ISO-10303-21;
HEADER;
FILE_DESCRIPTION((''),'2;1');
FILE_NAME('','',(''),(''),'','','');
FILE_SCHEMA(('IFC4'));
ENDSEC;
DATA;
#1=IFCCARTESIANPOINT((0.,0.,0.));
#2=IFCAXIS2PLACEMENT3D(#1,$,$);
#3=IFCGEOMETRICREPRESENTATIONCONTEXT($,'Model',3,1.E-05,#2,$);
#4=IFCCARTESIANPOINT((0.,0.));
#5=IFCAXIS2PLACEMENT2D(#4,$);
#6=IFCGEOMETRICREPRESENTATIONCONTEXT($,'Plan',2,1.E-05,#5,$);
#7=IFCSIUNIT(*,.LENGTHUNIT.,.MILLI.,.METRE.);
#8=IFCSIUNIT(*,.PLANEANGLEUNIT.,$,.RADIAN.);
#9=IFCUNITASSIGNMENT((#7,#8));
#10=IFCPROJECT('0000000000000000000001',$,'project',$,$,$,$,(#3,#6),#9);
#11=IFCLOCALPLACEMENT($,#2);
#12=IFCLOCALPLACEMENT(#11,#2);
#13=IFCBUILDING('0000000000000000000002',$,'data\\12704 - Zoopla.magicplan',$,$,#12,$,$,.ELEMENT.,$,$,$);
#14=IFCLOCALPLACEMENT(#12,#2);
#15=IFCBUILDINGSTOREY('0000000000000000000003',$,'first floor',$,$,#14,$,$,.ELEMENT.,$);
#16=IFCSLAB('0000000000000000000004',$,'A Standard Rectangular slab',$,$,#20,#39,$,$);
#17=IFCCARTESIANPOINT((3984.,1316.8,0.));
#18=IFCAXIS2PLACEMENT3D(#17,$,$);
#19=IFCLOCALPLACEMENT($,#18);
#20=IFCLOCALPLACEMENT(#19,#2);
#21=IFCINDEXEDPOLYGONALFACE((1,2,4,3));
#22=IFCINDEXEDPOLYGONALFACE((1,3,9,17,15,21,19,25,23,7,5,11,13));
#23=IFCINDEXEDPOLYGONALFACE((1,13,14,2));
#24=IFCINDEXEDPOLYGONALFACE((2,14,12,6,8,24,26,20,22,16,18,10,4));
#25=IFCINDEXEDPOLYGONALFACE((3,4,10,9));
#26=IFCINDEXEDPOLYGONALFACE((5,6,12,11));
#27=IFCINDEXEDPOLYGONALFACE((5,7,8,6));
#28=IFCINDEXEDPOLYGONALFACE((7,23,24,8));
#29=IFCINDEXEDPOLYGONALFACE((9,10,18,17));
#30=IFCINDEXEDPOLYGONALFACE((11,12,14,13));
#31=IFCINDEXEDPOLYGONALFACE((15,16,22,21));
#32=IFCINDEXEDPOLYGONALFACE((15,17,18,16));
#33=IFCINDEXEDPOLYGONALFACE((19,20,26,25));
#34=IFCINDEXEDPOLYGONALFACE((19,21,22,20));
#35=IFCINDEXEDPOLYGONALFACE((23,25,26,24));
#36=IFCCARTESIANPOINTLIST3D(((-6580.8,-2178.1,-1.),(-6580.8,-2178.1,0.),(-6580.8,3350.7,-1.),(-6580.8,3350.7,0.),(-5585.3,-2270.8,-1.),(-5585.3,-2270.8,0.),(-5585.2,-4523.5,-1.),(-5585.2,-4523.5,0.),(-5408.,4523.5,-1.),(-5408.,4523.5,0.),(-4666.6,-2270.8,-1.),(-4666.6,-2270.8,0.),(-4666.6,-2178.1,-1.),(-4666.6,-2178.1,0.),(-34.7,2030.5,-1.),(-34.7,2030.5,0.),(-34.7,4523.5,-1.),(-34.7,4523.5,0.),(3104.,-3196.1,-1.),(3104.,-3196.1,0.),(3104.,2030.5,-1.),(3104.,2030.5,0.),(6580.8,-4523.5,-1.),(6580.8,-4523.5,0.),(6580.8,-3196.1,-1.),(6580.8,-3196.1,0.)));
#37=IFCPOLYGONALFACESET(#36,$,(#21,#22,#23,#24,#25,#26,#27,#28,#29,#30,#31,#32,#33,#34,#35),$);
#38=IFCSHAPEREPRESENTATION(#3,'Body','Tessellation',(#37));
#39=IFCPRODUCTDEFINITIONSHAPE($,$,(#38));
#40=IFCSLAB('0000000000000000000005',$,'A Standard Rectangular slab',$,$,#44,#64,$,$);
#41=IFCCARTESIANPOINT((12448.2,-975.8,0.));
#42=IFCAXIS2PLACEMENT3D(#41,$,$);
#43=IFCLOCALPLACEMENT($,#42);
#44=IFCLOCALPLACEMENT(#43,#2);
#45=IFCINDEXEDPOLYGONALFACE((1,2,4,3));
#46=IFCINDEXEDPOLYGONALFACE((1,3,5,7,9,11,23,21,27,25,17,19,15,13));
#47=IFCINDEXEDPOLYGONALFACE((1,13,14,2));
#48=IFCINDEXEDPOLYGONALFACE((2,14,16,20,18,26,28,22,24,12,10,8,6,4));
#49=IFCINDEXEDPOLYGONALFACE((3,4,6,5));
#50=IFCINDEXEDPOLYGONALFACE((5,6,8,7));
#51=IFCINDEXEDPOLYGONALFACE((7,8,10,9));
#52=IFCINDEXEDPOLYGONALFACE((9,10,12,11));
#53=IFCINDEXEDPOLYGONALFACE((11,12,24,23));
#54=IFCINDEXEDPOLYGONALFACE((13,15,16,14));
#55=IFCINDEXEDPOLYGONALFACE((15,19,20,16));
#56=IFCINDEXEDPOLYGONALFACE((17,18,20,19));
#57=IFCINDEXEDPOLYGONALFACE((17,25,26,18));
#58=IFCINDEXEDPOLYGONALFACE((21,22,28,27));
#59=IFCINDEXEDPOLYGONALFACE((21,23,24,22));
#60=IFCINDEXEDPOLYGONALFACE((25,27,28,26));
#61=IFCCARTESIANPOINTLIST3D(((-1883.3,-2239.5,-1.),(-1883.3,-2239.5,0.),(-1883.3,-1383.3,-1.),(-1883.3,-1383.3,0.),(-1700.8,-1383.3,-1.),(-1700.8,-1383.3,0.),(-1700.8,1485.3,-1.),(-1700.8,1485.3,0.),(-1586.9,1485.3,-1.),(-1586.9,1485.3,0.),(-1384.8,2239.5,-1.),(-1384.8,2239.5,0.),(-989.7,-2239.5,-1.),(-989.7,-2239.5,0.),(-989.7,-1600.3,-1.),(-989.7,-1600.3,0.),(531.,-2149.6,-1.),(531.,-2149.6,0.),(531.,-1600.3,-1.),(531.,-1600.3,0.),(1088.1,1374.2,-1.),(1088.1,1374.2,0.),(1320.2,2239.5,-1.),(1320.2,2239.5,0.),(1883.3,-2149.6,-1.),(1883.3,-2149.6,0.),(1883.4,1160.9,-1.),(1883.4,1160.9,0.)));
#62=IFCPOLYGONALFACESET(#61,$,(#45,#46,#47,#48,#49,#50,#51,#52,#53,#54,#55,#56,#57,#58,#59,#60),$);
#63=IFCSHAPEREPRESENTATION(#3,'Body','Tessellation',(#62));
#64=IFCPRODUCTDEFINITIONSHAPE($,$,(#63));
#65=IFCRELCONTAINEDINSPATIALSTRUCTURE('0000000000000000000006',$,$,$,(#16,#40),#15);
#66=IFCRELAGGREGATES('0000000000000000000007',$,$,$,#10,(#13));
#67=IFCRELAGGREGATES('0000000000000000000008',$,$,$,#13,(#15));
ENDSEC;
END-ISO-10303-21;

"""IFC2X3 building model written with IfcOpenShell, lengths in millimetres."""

from ifc_helpers import new_model, si_unit, frame, origin, origin_2d, place, context, project, spatial, polyline, outline, extrude, element, save


model = new_model("IFC2X3")

# Units and contexts
model_context = context("Model", 3, precision=1e-05, world=origin())
plan_context = context("Plan", 2, precision=1e-05, world=origin_2d())
ifc_project = project(units=[si_unit("LENGTHUNIT", "METRE", prefix="MILLI"), si_unit("PLANEANGLEUNIT", "RADIAN")], contexts=[model_context, plan_context])

# Building, storey
placement_1 = place(None, origin())
building_placement = place(placement_1, origin())
building = spatial("IfcBuilding", under=ifc_project, at=building_placement, Name="data\\12704 - Zoopla.magicplan", CompositionType="ELEMENT")
storey_placement = place(building_placement, origin())
storey = spatial("IfcBuildingStorey", under=building, at=storey_placement, Name="first floor", CompositionType="ELEMENT")

# Slabs
placement_2 = place(None, frame((3984.0, 1316.8, 0.0)))
slab_1_placement = place(placement_2, origin())
element("IfcSlab", 1, at=slab_1_placement, inside=storey, Name="A Standard Rectangular slab", context=model_context, shape_type="SweptSolid", body=[
    extrude(outline(polyline([(-5585.2, -4523.5, 0.0), (-5585.3, -2270.8, 0.0), (-4666.6, -2270.8, 0.0), (-4666.6, -2178.1, 0.0), (-6580.8, -2178.1, 0.0), (-6580.8, 3350.7, 0.0), (-5408.0, 4523.5, 0.0), (-34.7, 4523.5, 0.0), (-34.7, 2030.5, 0.0), (3104.0, 2030.5, 0.0), (3104.0, -3196.1, 0.0), (6580.8, -3196.1, 0.0), (6580.8, -4523.5, 0.0), (-5585.2, -4523.5, 0.0)]), kind="CURVE"), origin(), (0.0, 0.0, -1.0), 1.0),
])
placement_3 = place(None, frame((12448.2, -975.8, 0.0)))
slab_2_placement = place(placement_3, origin())
element("IfcSlab", 2, at=slab_2_placement, inside=storey, Name="A Standard Rectangular slab", context=model_context, shape_type="SweptSolid", body=[
    extrude(outline(polyline([(1883.4, 1160.9, 0.0), (1883.3, -2149.6, 0.0), (531.0, -2149.6, 0.0), (531.0, -1600.3, 0.0), (-989.7, -1600.3, 0.0), (-989.7, -2239.5, 0.0), (-1883.4, -2239.5, 0.0), (-1883.4, -1383.3, 0.0), (-1700.8, -1383.3, 0.0), (-1700.8, 1485.3, 0.0), (-1586.9, 1485.3, 0.0), (-1384.8, 2239.5, 0.0), (1320.2, 2239.5, 0.0), (1088.1, 1374.2, 0.0), (1883.4, 1160.9, 0.0)]), kind="CURVE"), origin(), (0.0, 0.0, -1.0), 1.0),
])

save(model, "model.ifc")
